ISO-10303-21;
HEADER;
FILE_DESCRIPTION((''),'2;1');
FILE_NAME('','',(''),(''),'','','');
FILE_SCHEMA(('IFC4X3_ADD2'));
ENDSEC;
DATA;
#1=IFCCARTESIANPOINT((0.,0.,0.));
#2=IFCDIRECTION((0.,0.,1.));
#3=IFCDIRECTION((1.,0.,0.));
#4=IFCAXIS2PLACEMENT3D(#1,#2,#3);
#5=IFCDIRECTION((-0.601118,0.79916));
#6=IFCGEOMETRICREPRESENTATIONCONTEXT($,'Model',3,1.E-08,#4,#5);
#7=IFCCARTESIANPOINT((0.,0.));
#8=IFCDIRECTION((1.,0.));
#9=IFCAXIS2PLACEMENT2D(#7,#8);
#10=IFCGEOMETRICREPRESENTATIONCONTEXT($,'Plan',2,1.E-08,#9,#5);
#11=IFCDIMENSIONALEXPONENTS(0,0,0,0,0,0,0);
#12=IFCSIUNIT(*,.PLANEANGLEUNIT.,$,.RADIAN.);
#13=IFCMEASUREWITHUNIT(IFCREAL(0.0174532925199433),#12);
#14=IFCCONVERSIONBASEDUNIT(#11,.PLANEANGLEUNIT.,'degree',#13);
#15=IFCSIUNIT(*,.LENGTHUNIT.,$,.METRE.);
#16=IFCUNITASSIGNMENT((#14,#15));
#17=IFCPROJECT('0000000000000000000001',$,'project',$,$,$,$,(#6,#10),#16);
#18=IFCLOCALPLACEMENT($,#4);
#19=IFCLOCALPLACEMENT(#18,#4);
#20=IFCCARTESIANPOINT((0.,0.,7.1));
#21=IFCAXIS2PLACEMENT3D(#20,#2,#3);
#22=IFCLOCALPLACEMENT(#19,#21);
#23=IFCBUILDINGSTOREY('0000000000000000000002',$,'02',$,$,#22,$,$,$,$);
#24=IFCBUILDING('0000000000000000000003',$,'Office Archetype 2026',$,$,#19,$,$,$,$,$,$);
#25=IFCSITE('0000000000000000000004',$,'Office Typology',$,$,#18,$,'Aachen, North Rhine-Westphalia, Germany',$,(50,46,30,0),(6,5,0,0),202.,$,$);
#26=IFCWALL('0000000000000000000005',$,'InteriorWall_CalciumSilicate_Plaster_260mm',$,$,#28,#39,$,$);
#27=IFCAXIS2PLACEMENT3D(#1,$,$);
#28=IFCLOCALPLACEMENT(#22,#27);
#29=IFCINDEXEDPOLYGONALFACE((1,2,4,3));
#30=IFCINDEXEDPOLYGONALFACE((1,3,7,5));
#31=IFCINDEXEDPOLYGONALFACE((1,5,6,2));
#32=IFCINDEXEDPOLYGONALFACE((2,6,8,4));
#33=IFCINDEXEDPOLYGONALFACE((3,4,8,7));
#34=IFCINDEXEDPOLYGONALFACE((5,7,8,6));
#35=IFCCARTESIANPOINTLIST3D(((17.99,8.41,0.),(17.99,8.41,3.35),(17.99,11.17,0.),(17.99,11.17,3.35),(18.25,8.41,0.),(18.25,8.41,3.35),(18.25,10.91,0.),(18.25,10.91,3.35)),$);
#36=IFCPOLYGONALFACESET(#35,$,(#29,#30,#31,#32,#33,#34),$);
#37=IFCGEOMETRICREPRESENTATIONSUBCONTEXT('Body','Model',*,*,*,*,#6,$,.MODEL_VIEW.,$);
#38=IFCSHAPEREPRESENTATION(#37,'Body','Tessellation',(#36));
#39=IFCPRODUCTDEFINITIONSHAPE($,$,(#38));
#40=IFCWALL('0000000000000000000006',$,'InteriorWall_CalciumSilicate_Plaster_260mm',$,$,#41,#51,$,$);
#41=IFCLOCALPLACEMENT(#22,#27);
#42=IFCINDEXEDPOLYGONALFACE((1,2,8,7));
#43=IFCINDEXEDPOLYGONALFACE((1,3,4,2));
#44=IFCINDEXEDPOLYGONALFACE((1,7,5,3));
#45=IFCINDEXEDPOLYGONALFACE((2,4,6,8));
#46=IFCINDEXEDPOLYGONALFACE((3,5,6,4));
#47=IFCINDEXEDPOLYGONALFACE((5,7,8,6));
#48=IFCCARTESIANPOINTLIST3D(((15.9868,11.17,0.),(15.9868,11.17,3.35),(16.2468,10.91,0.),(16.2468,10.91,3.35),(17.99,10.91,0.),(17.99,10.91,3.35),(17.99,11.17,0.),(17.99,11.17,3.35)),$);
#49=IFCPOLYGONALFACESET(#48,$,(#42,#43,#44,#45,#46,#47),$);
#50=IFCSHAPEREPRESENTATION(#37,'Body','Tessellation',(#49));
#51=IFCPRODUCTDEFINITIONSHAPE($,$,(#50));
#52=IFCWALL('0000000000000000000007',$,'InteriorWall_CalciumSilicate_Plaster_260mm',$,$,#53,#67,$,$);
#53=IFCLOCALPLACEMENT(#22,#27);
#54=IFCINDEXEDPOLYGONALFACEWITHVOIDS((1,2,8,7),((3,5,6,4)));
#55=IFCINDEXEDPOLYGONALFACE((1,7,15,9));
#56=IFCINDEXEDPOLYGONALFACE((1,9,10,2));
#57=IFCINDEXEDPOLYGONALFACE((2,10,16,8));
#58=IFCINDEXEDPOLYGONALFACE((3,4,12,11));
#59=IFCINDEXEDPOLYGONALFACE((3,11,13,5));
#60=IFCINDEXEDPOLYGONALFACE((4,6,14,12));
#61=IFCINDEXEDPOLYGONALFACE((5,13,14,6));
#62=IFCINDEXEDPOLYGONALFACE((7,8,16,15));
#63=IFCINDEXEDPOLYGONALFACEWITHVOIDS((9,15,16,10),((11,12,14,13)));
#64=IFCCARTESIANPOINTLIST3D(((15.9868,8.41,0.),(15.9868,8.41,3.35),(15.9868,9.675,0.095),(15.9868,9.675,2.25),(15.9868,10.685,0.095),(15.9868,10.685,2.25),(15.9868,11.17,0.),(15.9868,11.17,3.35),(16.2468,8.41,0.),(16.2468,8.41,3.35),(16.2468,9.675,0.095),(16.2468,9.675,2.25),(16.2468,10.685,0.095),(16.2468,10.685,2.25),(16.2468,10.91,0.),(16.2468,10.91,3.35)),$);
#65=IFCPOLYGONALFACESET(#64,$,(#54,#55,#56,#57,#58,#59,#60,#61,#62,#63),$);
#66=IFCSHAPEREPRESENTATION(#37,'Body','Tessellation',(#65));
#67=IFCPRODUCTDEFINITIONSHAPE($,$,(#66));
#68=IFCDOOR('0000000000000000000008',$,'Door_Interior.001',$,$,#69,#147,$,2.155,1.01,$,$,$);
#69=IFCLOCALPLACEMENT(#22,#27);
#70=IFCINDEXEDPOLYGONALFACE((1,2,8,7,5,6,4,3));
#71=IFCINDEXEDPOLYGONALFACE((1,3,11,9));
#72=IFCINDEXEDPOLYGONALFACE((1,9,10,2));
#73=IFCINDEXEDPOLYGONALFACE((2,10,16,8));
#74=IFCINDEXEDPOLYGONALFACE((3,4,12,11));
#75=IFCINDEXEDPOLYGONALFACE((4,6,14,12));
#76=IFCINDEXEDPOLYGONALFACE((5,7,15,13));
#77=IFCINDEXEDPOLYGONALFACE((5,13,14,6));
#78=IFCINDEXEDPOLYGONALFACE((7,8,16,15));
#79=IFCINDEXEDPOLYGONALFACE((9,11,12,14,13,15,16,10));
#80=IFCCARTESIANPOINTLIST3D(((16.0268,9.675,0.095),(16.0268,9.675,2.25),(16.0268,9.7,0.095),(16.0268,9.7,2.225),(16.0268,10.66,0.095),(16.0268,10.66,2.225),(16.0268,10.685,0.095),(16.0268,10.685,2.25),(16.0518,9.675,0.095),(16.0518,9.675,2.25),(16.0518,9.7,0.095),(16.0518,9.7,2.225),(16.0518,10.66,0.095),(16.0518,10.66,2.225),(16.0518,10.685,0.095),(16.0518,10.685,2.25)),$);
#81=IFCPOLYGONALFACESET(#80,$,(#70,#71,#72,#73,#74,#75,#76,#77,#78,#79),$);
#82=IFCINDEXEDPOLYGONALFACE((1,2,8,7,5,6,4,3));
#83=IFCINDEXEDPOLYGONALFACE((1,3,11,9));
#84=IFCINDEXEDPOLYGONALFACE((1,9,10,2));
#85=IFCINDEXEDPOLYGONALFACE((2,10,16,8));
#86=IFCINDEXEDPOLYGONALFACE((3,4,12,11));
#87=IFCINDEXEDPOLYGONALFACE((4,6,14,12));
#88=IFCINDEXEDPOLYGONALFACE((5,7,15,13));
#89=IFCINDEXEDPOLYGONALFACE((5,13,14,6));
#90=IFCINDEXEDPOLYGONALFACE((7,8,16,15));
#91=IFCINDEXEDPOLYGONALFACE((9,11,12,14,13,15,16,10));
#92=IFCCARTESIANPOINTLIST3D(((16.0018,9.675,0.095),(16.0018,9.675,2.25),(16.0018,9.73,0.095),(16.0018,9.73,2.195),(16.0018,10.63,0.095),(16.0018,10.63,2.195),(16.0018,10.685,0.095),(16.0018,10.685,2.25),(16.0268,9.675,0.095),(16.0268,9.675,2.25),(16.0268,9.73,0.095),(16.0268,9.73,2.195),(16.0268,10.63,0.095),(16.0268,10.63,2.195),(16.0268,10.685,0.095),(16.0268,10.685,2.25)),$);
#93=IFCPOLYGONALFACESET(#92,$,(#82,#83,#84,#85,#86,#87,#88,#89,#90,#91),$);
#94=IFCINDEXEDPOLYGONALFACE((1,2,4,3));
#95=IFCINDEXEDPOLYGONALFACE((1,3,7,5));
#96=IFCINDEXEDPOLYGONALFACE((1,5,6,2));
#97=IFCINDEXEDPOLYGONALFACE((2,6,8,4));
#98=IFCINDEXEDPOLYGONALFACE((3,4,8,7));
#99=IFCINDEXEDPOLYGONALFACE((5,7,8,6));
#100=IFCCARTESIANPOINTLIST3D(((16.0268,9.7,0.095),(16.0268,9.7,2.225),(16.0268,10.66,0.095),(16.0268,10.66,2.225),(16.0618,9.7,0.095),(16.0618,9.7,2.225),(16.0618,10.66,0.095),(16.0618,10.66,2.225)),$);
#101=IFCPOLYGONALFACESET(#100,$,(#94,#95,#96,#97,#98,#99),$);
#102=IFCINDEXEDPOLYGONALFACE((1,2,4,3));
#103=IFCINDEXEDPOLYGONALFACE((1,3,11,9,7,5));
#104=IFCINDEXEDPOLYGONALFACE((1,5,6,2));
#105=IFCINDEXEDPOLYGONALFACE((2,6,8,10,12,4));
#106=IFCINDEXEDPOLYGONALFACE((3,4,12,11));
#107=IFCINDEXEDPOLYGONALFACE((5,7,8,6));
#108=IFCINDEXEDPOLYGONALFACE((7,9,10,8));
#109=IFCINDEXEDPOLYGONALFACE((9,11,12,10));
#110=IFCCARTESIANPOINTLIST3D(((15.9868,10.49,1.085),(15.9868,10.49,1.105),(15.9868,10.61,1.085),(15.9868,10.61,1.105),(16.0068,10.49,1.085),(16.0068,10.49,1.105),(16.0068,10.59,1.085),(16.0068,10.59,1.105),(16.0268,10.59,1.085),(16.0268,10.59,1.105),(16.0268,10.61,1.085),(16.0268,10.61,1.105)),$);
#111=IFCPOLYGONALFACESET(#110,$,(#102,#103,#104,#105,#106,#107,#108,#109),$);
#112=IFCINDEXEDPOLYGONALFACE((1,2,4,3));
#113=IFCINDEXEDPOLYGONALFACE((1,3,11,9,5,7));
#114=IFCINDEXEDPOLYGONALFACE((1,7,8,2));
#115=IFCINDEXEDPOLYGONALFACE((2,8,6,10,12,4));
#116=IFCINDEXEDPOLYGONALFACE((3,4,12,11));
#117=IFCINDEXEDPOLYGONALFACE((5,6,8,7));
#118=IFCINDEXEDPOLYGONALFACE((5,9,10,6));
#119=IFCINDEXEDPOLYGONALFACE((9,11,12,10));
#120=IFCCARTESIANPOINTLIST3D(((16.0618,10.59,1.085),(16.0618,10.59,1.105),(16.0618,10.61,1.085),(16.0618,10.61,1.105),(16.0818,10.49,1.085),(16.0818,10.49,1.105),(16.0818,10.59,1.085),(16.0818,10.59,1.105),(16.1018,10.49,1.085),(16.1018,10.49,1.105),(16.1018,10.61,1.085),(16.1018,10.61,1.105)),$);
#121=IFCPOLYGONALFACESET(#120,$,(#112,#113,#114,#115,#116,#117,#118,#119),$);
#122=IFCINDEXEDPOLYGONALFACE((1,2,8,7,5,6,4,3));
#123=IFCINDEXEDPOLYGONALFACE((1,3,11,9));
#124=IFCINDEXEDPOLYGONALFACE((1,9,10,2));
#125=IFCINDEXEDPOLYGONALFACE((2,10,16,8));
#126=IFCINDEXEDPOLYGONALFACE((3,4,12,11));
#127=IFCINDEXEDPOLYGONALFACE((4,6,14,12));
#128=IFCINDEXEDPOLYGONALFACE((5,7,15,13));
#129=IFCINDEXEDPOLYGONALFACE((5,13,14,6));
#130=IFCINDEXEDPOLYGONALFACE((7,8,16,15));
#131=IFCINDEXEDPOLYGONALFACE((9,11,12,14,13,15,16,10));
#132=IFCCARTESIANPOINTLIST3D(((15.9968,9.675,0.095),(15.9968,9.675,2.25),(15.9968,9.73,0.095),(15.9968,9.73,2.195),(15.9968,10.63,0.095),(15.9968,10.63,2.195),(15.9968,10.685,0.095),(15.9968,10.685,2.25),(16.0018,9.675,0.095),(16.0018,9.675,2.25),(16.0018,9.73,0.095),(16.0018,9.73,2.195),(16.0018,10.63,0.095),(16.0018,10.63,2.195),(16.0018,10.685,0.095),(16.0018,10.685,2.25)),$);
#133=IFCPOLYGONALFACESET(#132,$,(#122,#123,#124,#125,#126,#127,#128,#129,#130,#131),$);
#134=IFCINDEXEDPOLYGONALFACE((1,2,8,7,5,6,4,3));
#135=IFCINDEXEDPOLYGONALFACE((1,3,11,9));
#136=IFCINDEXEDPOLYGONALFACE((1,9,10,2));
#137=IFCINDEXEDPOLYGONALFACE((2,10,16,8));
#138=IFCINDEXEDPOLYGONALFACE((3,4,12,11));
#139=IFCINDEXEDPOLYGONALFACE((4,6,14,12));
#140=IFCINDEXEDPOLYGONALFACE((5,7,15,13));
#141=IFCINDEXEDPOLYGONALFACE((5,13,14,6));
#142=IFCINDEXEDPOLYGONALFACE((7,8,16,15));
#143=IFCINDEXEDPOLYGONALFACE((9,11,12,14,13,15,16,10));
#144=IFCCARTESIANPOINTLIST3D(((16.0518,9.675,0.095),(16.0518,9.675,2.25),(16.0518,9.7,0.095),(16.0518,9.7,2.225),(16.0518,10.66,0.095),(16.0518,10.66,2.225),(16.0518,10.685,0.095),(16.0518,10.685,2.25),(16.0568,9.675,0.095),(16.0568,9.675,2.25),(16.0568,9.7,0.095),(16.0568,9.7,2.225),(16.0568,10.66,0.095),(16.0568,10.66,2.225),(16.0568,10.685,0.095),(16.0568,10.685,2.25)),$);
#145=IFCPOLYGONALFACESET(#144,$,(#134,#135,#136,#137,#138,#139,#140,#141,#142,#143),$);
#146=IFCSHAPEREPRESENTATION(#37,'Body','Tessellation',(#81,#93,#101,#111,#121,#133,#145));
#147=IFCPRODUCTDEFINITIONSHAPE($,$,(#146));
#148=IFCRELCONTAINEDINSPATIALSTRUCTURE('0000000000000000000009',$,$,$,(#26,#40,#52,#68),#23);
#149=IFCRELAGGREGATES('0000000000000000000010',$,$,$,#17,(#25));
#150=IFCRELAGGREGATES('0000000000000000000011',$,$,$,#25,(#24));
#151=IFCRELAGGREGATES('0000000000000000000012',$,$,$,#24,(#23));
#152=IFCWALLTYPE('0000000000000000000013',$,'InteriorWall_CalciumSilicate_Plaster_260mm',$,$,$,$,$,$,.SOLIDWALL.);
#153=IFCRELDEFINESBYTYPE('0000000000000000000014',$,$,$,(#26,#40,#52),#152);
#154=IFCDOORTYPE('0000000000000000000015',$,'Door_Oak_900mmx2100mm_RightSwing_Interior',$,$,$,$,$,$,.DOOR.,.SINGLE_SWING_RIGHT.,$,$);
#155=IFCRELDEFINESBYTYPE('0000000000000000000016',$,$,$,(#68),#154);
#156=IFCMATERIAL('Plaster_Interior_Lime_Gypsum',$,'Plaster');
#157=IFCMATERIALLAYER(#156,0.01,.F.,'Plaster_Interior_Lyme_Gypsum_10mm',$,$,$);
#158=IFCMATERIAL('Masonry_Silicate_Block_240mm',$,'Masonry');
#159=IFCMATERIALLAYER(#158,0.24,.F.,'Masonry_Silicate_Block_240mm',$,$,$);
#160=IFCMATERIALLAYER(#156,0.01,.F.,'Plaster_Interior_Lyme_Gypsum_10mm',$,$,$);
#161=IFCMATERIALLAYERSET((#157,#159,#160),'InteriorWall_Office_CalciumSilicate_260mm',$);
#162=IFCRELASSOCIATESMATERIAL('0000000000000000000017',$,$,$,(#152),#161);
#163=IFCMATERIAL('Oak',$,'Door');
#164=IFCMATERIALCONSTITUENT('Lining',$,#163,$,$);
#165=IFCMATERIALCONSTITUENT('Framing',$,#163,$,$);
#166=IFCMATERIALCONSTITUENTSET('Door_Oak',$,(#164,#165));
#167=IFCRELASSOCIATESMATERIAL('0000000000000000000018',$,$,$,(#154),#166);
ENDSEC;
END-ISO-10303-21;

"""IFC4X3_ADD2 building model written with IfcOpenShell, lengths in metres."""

from ifc_helpers import new_model, entity, si_unit, converted_unit, direction, frame, origin_with_axes, origin_2d_with_axis, place, context, subcontext, project, spatial, line, indexed_curve, outline, extrude, source, transform, mapped, material, layer, layer_set, constituent, constituent_set, type_object, type_shapes, element, fill, save


model = new_model("IFC4X3_ADD2")

# Units and contexts
model_context = context("Model", 3, precision=1e-08, world=origin_with_axes(), true_north=direction((-0.601118, 0.79916)))
plan_context = context("Plan", 2, precision=1e-08, world=origin_2d_with_axis(), true_north=direction((-0.601118, 0.79916)))
body_context = subcontext(model_context, "Body", "Model", "MODEL_VIEW")
ifc_project = project(units=[converted_unit("PLANEANGLEUNIT", "degree", entity("IfcReal", 0.0174532925199433), si_unit("PLANEANGLEUNIT", "RADIAN"), dimensions=[0, 0, 0, 0, 0, 0, 0]), si_unit("LENGTHUNIT", "METRE")], contexts=[model_context, plan_context])

# Site, building, storey
site_placement = place(None, origin_with_axes())
site = spatial("IfcSite", under=ifc_project, at=site_placement, Name="Office Typology", LongName="Aachen, North Rhine-Westphalia, Germany", RefLatitude=(50, 46, 30, 0), RefLongitude=(6, 5, 0, 0), RefElevation=202.0)
building_placement = place(site_placement, origin_with_axes())
building = spatial("IfcBuilding", under=site, at=building_placement, Name="Office Archetype 2026")
storey_placement = place(building_placement, frame((0.0, 0.0, 7.1), z_axis=(0.0, 0.0, 1.0), x_axis=(1.0, 0.0, 0.0)))
storey = spatial("IfcBuildingStorey", under=building, at=storey_placement, Name="02")

# Walls
ifc_material_1 = material(Name="Plaster_Interior_Lime_Gypsum", Category="Plaster")
ifc_layer_1 = layer(ifc_material_1, 0.01, ventilated=False, Name="Plaster_Interior_Lyme_Gypsum_10mm")
ifc_material_2 = material(Name="Masonry_Silicate_Block_240mm", Category="Masonry")
ifc_layer_2 = layer(ifc_material_2, 0.24, ventilated=False, Name="Masonry_Silicate_Block_240mm")
ifc_layer_3 = layer(ifc_material_1, 0.01, ventilated=False, Name="Plaster_Interior_Lyme_Gypsum_10mm")
ifc_layer_set_1 = layer_set([ifc_layer_1, ifc_layer_2, ifc_layer_3], Name="InteriorWall_Office_CalciumSilicate_260mm")
wall_type_1 = type_object("IfcWallType", Name="InteriorWall_CalciumSilicate_Plaster_260mm", PredefinedType="SOLIDWALL", material=ifc_layer_set_1)
wall_1_placement = place(storey_placement, frame((17.99, 11.17, 0.0), z_axis=(0.0, 0.0, 1.0), x_axis=(0.0, -1.0, 0.0)))
element("IfcWall", 1, at=wall_1_placement, inside=storey, type_object=wall_type_1, Name="InteriorWall_CalciumSilicate_Plaster_260mm", context=body_context, shape_type="SweptSolid", body=[
    extrude(outline(indexed_curve([(0.0, 0.0), (0.26, 0.26), (2.76, 0.26), (2.76, 0.0)], segments=[line(1, 2, 3, 4, 1)])), origin_with_axes(), (0.0, 0.0, 1.0), 3.35),
])
wall_2_placement = place(storey_placement, frame((17.99, 11.17, 0.0), z_axis=(0.0, 0.0, 1.0), x_axis=(-1.0, 0.0, 0.0)))
element("IfcWall", 2, at=wall_2_placement, inside=storey, type_object=wall_type_1, Name="InteriorWall_CalciumSilicate_Plaster_260mm", context=body_context, shape_type="SweptSolid", body=[
    extrude(outline(indexed_curve([(0.0, 0.0), (0.0, 0.26), (1.7432, 0.26), (2.0032, 0.0)], segments=[line(1, 2, 3, 4, 1)])), origin_with_axes(), (0.0, 0.0, 1.0), 3.35),
])

# Wall, opening, door
wall_3_placement = place(storey_placement, frame((15.9868, 11.17, 0.0), z_axis=(0.0, 0.0, 1.0), x_axis=(0.0, -1.0, 0.0)))
wall_3 = element("IfcWall", 3, at=wall_3_placement, inside=storey, type_object=wall_type_1, Name="InteriorWall_CalciumSilicate_Plaster_260mm", context=body_context, shape_type="SweptSolid", body=[
    extrude(outline(indexed_curve([(0.0, 0.0), (0.26, 0.26), (2.76, 0.26), (2.76, 0.0)], segments=[line(1, 2, 3, 4, 1)])), origin_with_axes(), (0.0, 0.0, 1.0), 3.35),
])
shared_shape_1 = source(origin_with_axes(), body_context, "Body", "SweptSolid", [
    extrude(outline(indexed_curve([(0.0, 2.155), (1.01, 2.155), (1.01, 0.0), (0.0, 0.0), (0.0, 2.155)])), frame((0.0, 0.0, 0.0), z_axis=(0.0, -1.0, 0.0), x_axis=(1.0, 0.0, 0.0)), (0.0, 0.0, -1.0), 0.26),
])
opening_1_placement = place(wall_3_placement, frame((0.485, 0.0, 0.095), z_axis=(0.0, 0.0, 1.0), x_axis=(1.0, 0.0, 0.0)))
opening_1 = element("IfcOpeningElement", 4, at=opening_1_placement, cuts=wall_3, PredefinedType="OPENING", context=body_context, shape_type="MappedRepresentation", body=[
    mapped(shared_shape_1, transform((0.0, 0.0, 0.0), x_axis=(1.0, 0.0, 0.0), y_axis=(0.0, 1.0, 0.0), z_axis=(0.0, 0.0, 1.0), scale=1.0)),
])
ifc_material_3 = material(Name="Oak", Category="Door")
ifc_constituent_1 = constituent(ifc_material_3, Name="Lining")
ifc_constituent_2 = constituent(ifc_material_3, Name="Framing")
ifc_constituent_set_1 = constituent_set(constituents=[ifc_constituent_1, ifc_constituent_2], Name="Door_Oak")
door_type_1 = type_object("IfcDoorType", Name="Door_Oak_900mmx2100mm_RightSwing_Interior", OperationType="SINGLE_SWING_RIGHT", PredefinedType="DOOR", material=ifc_constituent_set_1)
shared_shape_2 = source(origin_with_axes(), body_context, "Body", "SweptSolid", [
    extrude(outline(indexed_curve([(0.0, 0.0), (0.0, 2.155), (1.01, 2.155), (1.01, 0.0), (0.985, 0.0), (0.985, 2.13), (0.025, 2.13), (0.025, 0.0)], segments=[line(1, 2, 3, 4, 5, 6, 7, 8, 1)])), frame((0.0, 0.025, 0.0), z_axis=(0.0, -1.0, 0.0), x_axis=(1.0, 0.0, 0.0)), (0.0, 0.0, -1.0), 0.025),
    extrude(outline(indexed_curve([(0.0, 0.0), (0.0, 2.155), (1.01, 2.155), (1.01, 0.0), (0.955, 0.0), (0.955, 2.1), (0.055, 2.1), (0.055, 0.0)], segments=[line(1, 2, 3, 4, 5, 6, 7, 8, 1)])), frame((0.0, 0.0, 0.0), z_axis=(0.0, -1.0, 0.0), x_axis=(1.0, 0.0, 0.0)), (0.0, 0.0, -1.0), 0.025),
    extrude(outline(indexed_curve([(0.0, 0.0), (0.96, 0.0), (0.96, 0.035), (0.0, 0.035)], segments=[line(1, 2, 3, 4, 1)])), frame((0.025, 0.025, 0.0), z_axis=(0.0, 0.0, 1.0), x_axis=(1.0, 0.0, 0.0)), (0.0, 0.0, 1.0), 2.13),
    extrude(outline(indexed_curve([(0.0, 0.0), (0.0, -0.04), (0.12, -0.04), (0.12, -0.02), (0.02, -0.02), (0.02, 0.0)], segments=[line(1, 2, 3, 4, 5, 6, 1)])), frame((0.075, 0.025, 0.99), z_axis=(0.0, 0.0, 1.0), x_axis=(1.0, 0.0, 0.0)), (0.0, 0.0, 1.0), 0.02),
    extrude(outline(indexed_curve([(0.0, 0.0), (0.0, 0.04), (0.12, 0.04), (0.12, 0.02), (0.02, 0.02), (0.02, 0.0)], segments=[line(1, 2, 3, 4, 5, 6, 1)])), frame((0.075, 0.06, 0.99), z_axis=(0.0, 0.0, 1.0), x_axis=(1.0, 0.0, 0.0)), (0.0, 0.0, 1.0), 0.02),
    extrude(outline(indexed_curve([(0.0, 0.0), (0.0, 2.155), (1.01, 2.155), (1.01, 0.0), (0.955, 0.0), (0.955, 2.1), (0.055, 2.1), (0.055, 0.0)], segments=[line(1, 2, 3, 4, 5, 6, 7, 8, 1)])), frame((0.0, -0.005, 0.0), z_axis=(0.0, -1.0, 0.0), x_axis=(1.0, 0.0, 0.0)), (0.0, 0.0, -1.0), 0.005),
    extrude(outline(indexed_curve([(0.0, 0.0), (0.0, 2.155), (1.01, 2.155), (1.01, 0.0), (0.985, 0.0), (0.985, 2.13), (0.025, 2.13), (0.025, 0.0)], segments=[line(1, 2, 3, 4, 5, 6, 7, 8, 1)])), frame((0.0, 0.05, 0.0), z_axis=(0.0, -1.0, 0.0), x_axis=(1.0, 0.0, 0.0)), (0.0, 0.0, -1.0), 0.005),
])
type_shapes(door_type_1, [shared_shape_2])
door_1_placement = place(opening_1_placement, frame((0.0, 0.015, 0.0), z_axis=(0.0, 0.0, 1.0), x_axis=(1.0, 0.0, 0.0)))
door_1 = element("IfcDoor", 5, at=door_1_placement, inside=storey, type_object=door_type_1, Name="Door_Interior.001", OverallHeight=2.155, OverallWidth=1.01, context=body_context, shape_type="MappedRepresentation", body=[
    mapped(shared_shape_2, transform((0.0, 0.0, 0.0), x_axis=(1.0, 0.0, 0.0), y_axis=(0.0, 1.0, 0.0), z_axis=(0.0, 0.0, 1.0), scale=1.0)),
])
fill(opening_1, door_1)

save(model, "model.ifc")
